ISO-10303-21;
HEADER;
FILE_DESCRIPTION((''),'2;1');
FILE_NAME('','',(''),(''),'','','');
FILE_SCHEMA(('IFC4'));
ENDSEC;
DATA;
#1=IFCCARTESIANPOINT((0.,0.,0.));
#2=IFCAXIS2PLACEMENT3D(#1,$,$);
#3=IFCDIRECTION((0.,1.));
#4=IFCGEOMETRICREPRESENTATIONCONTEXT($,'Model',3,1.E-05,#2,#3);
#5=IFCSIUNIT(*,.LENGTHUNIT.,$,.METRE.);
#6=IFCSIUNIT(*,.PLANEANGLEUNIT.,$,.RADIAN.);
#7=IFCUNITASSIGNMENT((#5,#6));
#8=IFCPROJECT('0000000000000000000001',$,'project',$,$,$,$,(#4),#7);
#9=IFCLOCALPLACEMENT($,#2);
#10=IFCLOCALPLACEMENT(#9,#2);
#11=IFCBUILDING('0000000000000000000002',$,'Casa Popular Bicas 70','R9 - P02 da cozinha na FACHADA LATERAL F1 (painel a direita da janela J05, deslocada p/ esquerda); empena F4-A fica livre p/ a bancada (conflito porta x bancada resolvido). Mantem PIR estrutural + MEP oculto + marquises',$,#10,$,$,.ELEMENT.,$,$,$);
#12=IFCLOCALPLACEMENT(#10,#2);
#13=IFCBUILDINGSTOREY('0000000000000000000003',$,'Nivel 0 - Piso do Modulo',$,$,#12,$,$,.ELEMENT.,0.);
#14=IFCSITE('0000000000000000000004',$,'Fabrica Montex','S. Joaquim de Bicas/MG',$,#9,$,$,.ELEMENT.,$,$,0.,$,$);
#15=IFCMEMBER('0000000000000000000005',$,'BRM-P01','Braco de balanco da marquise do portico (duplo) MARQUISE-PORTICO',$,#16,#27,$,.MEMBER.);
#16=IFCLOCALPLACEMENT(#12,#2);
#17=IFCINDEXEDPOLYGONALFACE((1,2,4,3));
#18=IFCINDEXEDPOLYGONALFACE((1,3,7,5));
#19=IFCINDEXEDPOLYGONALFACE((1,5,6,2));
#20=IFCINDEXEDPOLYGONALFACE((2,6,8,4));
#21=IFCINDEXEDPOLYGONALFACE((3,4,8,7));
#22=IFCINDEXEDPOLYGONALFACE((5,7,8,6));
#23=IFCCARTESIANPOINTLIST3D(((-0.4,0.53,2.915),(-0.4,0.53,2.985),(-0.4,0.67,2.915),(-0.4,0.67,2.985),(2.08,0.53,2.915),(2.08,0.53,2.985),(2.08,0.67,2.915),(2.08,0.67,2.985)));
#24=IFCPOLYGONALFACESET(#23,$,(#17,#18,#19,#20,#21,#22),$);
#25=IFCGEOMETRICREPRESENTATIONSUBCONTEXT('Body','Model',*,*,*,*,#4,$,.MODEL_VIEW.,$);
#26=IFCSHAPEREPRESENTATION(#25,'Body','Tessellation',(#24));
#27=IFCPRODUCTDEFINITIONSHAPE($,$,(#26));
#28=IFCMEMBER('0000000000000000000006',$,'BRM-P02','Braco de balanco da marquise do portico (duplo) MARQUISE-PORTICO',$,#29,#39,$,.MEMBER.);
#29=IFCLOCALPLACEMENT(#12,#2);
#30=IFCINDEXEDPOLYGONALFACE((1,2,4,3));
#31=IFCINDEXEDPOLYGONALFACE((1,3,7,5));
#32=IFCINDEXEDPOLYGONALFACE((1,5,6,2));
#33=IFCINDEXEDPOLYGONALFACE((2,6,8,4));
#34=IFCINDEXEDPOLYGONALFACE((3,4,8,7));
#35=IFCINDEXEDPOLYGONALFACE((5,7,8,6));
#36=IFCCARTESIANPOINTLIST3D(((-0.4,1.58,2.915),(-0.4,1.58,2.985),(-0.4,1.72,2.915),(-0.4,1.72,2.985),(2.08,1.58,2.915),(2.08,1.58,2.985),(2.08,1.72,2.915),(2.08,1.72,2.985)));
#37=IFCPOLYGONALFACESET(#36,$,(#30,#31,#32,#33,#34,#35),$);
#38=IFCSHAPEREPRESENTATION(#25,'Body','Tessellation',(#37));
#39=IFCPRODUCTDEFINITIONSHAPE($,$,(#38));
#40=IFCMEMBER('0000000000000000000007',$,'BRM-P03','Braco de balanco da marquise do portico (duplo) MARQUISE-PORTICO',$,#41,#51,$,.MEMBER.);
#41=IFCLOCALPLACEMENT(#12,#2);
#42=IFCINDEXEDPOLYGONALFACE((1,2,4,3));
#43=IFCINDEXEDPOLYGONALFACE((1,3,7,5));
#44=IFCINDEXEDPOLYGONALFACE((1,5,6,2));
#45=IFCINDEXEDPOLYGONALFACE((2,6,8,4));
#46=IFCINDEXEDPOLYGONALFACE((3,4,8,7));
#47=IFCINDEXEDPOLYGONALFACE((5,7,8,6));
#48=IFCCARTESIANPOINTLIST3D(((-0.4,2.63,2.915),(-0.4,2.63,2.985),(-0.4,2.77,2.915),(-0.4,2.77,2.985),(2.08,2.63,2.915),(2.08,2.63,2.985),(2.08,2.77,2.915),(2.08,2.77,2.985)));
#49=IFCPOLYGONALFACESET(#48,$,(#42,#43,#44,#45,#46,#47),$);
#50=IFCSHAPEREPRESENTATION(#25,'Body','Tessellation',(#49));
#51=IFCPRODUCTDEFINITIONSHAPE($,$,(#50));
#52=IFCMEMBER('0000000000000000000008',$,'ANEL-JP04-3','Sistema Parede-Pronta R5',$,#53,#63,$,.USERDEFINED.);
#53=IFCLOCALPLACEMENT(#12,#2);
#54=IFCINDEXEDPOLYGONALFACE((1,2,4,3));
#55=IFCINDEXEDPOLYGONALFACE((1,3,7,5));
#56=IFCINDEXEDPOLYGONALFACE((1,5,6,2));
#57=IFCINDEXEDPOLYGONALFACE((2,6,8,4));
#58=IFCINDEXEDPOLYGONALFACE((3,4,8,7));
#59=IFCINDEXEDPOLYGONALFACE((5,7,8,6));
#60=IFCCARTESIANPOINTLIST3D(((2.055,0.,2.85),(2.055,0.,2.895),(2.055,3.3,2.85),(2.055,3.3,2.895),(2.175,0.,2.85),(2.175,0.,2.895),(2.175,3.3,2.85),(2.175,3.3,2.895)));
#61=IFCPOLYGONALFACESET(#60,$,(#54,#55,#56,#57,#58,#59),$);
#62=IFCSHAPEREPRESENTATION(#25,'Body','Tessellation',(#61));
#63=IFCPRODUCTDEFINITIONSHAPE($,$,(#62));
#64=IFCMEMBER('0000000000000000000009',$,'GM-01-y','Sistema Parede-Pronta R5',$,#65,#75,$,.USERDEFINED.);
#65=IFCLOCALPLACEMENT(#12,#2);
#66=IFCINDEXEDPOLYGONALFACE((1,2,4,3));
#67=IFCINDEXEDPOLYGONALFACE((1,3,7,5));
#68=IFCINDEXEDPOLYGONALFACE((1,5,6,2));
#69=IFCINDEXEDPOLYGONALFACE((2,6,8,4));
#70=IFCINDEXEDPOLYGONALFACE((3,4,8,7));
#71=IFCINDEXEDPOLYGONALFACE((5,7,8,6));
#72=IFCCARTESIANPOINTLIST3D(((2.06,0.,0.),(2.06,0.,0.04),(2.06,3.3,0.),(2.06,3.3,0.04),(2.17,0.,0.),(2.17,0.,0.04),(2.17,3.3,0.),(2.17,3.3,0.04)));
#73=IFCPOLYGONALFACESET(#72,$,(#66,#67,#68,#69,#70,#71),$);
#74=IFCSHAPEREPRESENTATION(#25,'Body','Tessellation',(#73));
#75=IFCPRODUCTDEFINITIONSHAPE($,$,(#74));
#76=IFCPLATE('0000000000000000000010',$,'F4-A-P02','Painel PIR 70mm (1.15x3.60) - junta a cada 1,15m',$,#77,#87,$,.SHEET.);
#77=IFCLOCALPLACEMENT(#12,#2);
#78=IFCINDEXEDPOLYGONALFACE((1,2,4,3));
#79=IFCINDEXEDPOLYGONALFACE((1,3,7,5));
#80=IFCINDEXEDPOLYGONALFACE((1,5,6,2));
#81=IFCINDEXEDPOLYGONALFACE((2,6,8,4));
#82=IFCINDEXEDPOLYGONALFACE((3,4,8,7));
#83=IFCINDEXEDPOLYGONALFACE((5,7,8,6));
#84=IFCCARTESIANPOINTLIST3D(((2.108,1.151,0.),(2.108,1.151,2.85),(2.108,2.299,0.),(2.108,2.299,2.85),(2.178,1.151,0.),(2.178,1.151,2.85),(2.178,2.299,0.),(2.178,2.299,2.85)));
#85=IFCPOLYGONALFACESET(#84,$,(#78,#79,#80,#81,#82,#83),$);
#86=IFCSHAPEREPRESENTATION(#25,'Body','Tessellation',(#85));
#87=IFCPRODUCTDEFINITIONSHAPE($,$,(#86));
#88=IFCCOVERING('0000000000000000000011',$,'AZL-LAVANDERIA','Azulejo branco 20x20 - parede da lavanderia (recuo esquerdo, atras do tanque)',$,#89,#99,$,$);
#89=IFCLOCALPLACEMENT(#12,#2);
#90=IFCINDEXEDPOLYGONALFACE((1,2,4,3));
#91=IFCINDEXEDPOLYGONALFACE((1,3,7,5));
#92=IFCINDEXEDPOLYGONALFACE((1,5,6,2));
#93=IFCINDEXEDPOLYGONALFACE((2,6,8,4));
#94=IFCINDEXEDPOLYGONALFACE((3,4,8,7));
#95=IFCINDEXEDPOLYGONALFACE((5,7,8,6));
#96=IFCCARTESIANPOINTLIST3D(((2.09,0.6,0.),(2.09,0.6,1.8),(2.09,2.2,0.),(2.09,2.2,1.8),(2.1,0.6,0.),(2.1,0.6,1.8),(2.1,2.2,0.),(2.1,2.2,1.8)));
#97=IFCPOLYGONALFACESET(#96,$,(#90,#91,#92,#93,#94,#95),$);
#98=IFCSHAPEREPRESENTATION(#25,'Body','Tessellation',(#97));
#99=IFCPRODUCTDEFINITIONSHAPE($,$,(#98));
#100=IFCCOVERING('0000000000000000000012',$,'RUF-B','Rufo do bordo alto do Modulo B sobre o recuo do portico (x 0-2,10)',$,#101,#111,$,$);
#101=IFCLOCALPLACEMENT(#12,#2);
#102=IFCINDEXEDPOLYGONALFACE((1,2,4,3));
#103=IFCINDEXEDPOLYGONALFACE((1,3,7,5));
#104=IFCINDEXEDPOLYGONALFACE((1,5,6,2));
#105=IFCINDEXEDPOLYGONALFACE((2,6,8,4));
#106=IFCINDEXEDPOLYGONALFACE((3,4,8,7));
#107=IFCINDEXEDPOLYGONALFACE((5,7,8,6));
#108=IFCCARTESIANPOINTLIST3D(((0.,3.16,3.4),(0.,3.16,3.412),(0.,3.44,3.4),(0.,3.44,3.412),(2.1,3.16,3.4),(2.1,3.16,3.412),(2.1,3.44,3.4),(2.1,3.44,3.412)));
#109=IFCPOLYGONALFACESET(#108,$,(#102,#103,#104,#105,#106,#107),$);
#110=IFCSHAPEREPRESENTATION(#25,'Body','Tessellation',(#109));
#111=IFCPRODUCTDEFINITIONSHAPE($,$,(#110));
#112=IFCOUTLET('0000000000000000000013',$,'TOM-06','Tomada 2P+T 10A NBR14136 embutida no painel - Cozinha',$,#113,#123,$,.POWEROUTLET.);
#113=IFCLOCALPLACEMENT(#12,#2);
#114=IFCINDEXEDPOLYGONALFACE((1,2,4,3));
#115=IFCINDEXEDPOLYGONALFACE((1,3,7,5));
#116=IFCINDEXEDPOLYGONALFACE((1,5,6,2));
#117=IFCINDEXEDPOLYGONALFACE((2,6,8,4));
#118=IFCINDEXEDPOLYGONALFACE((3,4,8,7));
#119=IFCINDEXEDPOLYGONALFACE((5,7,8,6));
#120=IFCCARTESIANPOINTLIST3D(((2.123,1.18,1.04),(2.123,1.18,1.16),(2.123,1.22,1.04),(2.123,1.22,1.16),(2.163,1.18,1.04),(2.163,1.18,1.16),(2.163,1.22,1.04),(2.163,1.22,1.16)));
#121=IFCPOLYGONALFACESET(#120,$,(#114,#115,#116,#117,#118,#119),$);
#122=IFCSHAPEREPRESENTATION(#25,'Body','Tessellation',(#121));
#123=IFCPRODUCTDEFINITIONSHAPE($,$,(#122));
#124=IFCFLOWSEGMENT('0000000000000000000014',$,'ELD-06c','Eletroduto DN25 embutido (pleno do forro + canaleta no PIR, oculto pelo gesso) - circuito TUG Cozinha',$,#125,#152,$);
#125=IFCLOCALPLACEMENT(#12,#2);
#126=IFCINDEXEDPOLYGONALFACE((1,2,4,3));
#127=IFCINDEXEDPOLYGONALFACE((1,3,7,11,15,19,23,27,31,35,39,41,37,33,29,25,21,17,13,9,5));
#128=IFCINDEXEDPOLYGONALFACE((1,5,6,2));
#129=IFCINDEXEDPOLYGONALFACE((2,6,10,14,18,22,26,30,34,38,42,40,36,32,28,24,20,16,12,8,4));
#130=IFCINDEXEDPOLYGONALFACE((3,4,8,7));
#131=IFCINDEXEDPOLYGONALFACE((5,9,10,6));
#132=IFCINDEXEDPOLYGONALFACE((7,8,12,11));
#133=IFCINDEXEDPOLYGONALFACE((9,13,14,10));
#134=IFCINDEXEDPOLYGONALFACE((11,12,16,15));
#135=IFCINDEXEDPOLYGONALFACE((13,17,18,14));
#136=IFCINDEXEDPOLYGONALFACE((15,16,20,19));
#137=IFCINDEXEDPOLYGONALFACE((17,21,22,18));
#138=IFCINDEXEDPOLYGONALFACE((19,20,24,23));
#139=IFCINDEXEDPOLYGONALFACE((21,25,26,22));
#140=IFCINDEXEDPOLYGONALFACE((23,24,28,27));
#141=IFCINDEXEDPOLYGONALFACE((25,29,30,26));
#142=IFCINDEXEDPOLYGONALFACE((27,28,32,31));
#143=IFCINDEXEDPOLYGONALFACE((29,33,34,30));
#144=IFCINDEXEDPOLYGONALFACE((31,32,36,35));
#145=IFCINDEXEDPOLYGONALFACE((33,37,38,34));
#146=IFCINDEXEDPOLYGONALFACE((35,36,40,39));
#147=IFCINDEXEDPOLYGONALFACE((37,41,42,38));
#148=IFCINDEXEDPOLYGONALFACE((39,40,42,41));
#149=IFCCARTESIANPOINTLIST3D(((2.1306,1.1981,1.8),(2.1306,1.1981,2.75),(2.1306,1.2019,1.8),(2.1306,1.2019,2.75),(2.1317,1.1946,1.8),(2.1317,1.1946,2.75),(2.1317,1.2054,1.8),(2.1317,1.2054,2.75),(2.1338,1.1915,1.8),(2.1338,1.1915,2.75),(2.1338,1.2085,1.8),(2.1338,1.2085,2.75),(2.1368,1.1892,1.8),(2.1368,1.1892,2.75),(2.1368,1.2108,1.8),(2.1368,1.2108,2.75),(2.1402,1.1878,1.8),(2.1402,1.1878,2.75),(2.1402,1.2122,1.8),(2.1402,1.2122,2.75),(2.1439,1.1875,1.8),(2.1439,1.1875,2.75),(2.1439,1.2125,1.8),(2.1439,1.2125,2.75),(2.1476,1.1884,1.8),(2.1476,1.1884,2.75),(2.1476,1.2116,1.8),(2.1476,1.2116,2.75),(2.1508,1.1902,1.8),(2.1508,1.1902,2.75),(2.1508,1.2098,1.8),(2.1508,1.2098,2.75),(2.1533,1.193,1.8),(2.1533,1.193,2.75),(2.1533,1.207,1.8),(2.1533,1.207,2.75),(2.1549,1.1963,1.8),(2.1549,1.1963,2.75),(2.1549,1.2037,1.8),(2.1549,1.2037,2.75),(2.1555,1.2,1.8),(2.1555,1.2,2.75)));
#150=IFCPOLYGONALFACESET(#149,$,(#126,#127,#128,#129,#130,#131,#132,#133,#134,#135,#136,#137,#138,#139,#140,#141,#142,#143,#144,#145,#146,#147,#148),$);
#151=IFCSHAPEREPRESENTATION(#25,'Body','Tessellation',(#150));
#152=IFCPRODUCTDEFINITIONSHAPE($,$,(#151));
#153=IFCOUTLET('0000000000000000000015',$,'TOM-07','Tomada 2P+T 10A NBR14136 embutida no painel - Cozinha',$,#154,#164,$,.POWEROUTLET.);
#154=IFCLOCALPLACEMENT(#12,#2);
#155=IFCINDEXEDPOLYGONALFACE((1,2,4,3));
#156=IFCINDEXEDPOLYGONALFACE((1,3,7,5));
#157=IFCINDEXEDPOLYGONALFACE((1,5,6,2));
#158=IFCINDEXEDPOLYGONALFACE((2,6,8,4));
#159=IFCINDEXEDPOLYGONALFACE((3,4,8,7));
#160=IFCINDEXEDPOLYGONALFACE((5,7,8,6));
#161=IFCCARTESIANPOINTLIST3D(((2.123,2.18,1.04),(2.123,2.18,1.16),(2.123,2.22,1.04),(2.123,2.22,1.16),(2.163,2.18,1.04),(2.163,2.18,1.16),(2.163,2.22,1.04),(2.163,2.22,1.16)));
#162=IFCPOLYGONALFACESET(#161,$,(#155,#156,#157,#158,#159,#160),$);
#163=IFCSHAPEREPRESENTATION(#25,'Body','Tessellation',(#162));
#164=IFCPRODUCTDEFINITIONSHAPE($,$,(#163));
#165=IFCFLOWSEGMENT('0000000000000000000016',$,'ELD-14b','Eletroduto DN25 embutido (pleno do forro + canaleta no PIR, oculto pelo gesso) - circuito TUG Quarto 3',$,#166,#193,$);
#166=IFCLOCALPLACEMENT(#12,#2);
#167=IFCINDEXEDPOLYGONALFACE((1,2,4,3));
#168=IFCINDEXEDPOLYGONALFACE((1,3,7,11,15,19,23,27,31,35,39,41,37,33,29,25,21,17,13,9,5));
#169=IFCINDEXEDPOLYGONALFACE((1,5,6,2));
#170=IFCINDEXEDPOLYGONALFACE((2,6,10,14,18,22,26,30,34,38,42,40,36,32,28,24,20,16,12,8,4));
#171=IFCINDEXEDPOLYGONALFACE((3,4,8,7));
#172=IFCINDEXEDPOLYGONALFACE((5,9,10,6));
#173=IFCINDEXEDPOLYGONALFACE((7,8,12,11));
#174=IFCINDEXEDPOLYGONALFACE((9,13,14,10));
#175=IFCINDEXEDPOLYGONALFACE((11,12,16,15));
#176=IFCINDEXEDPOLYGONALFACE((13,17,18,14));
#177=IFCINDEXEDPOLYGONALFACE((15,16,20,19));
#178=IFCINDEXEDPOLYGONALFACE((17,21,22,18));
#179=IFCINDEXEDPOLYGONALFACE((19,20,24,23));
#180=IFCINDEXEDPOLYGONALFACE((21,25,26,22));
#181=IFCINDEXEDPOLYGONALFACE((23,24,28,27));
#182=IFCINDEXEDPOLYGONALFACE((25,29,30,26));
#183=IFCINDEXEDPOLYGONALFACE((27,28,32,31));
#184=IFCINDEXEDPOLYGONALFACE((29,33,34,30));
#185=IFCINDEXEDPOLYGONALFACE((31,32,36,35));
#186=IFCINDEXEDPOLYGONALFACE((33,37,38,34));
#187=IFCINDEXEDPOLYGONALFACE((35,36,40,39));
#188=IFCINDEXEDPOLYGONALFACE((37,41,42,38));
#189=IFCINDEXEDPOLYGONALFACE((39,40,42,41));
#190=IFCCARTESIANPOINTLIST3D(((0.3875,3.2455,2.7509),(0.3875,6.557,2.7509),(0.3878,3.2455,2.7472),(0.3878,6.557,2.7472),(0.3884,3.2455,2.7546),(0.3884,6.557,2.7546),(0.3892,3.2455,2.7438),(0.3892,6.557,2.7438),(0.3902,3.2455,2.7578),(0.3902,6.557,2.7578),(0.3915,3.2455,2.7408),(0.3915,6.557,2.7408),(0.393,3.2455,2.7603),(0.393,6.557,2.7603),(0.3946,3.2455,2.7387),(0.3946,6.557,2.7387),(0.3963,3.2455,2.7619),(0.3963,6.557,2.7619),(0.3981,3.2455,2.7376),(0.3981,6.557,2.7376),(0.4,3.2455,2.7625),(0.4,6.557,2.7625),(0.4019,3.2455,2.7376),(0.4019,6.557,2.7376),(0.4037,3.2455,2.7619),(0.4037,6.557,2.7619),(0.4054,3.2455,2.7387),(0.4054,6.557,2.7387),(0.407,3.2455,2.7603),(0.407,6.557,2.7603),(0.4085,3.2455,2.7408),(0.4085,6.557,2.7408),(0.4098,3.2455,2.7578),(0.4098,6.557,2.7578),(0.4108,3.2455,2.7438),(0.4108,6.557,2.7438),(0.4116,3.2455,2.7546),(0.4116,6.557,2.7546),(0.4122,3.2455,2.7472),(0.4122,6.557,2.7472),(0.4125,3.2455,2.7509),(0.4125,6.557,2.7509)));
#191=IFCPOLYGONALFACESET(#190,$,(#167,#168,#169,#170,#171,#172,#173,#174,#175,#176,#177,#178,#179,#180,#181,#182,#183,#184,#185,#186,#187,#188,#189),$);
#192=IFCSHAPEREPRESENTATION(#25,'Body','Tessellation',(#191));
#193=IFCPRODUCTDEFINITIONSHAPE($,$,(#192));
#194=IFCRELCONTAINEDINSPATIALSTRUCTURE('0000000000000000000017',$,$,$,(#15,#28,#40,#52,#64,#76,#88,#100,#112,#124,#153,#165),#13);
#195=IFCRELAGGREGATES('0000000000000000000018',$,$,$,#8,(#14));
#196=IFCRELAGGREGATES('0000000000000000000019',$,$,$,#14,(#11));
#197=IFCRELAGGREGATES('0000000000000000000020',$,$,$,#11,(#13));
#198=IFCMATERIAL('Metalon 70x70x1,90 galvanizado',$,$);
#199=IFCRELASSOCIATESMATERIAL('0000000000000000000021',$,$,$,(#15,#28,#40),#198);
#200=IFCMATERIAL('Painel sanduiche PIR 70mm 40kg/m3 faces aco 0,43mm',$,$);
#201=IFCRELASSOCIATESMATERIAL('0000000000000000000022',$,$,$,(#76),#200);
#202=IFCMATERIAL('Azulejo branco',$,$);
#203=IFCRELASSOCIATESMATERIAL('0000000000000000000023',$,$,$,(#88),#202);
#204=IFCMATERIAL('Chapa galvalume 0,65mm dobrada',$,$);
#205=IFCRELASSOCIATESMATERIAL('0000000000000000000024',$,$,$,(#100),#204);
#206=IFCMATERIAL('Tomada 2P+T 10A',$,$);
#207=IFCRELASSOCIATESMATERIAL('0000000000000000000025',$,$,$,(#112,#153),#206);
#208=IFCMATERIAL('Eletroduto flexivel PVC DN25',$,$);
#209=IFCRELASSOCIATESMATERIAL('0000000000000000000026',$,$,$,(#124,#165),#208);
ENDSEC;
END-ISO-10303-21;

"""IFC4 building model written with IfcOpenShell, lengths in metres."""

from ifc_helpers import new_model, si_unit, direction, frame, frame_2d, origin, origin_2d, place, context, subcontext, project, spatial, rectangle, circle, extrude, material, element, save


model = new_model("IFC4")

# Units and contexts
model_context = context("Model", 3, precision=1e-05, world=origin(), true_north=direction((0.0, 1.0)))
body_context = subcontext(model_context, "Body", "Model", "MODEL_VIEW")
ifc_project = project(units=[si_unit("LENGTHUNIT", "METRE"), si_unit("PLANEANGLEUNIT", "RADIAN")], contexts=[model_context])

# Site, building, storey
site_placement = place(None, origin())
site = spatial("IfcSite", under=ifc_project, at=site_placement, Name="Fabrica Montex", Description="S. Joaquim de Bicas/MG", CompositionType="ELEMENT", RefElevation=0.0)
building_placement = place(site_placement, origin())
building = spatial("IfcBuilding", under=site, at=building_placement, Name="Casa Popular Bicas 70", Description="R9 - P02 da cozinha na FACHADA LATERAL F1 (painel a direita da janela J05, deslocada p/ esquerda); empena F4-A fica livre p/ a bancada (conflito porta x bancada resolvido). Mantem PIR estrutural + MEP oculto + marquises", CompositionType="ELEMENT")
storey_placement = place(building_placement, origin())
storey = spatial("IfcBuildingStorey", under=building, at=storey_placement, Name="Nivel 0 - Piso do Modulo", CompositionType="ELEMENT", Elevation=0.0)

# Members
ifc_material_1 = material(Name="Metalon 70x70x1,90 galvanizado")
for number, where, z_axis, x_axis, name in (
    (1, (2.08, 0.6, 2.95), (-1.0, 0.0, 0.0), (0.0, 0.0, 1.0), "BRM-P01"),
    (2, (2.08, 1.65, 2.95), (-1.0, 0.0, 0.0), (0.0, 0.0, 1.0), "BRM-P02"),
    (3, (2.08, 2.7, 2.95), (-1.0, 0.0, 0.0), (0.0, 0.0, 1.0), "BRM-P03"),
):
    element("IfcMember", number, at=place(storey_placement, frame(where, z_axis=z_axis, x_axis=x_axis)), inside=storey, material=ifc_material_1, Name=name, Description="Braco de balanco da marquise do portico (duplo) MARQUISE-PORTICO", PredefinedType="MEMBER", context=body_context, shape_type="SweptSolid", body=[
        extrude(rectangle(XDim=0.07, YDim=0.14, at=origin_2d()), origin(), (0.0, 0.0, 1.0), 2.48),
    ])
member_1_placement = place(storey_placement, frame((2.115, 1.65, 2.85)))
element("IfcMember", 4, at=member_1_placement, inside=storey, Name="ANEL-JP04-3", Description="Sistema Parede-Pronta R5", PredefinedType="USERDEFINED", context=body_context, shape_type="SweptSolid", body=[
    extrude(rectangle(XDim=0.12, YDim=3.3, at=origin_2d()), origin(), (0.0, 0.0, 1.0), 0.045),
])
member_2_placement = place(storey_placement, frame((2.115, 1.65, 0.0)))
element("IfcMember", 5, at=member_2_placement, inside=storey, Name="GM-01-y", Description="Sistema Parede-Pronta R5", PredefinedType="USERDEFINED", context=body_context, shape_type="SweptSolid", body=[
    extrude(rectangle(XDim=0.11, YDim=3.3, at=origin_2d()), origin(), (0.0, 0.0, 1.0), 0.04),
])

# Plate
ifc_material_2 = material(Name="Painel sanduiche PIR 70mm 40kg/m3 faces aco 0,43mm")
plate_placement = place(storey_placement, frame((2.143, 1.151, 0.0), x_axis=(0.0, 1.0, 0.0)))
element("IfcPlate", 6, at=plate_placement, inside=storey, material=ifc_material_2, Name="F4-A-P02", Description="Painel PIR 70mm (1.15x3.60) - junta a cada 1,15m", PredefinedType="SHEET", context=body_context, shape_type="SweptSolid", body=[
    extrude(rectangle(XDim=1.148, YDim=0.07, at=frame_2d((0.574, 0.0))), origin(), (0.0, 0.0, 1.0), 2.85),
])

# Coverings
ifc_material_3 = material(Name="Azulejo branco")
covering_1_placement = place(storey_placement, frame((2.095, 0.6, 0.0), x_axis=(0.0, 1.0, 0.0)))
element("IfcCovering", 7, at=covering_1_placement, inside=storey, material=ifc_material_3, Name="AZL-LAVANDERIA", Description="Azulejo branco 20x20 - parede da lavanderia (recuo esquerdo, atras do tanque)", context=body_context, shape_type="SweptSolid", body=[
    extrude(rectangle(XDim=1.6, YDim=0.01, at=frame_2d((0.8, 0.0))), origin(), (0.0, 0.0, 1.0), 1.8),
])
ifc_material_4 = material(Name="Chapa galvalume 0,65mm dobrada")
covering_2_placement = place(storey_placement, frame((0.0, 3.16, 3.4), x_axis=(1.0, 0.0, 0.0)))
element("IfcCovering", 8, at=covering_2_placement, inside=storey, material=ifc_material_4, Name="RUF-B", Description="Rufo do bordo alto do Modulo B sobre o recuo do portico (x 0-2,10)", context=body_context, shape_type="SweptSolid", body=[
    extrude(rectangle(XDim=2.1, YDim=0.28, at=frame_2d((1.05, 0.14))), origin(), (0.0, 0.0, 1.0), 0.012),
])

# Outlet
ifc_material_5 = material(Name="Tomada 2P+T 10A")
outlet_1_placement = place(storey_placement, frame((2.123, 1.18, 1.04)))
element("IfcOutlet", 9, at=outlet_1_placement, inside=storey, material=ifc_material_5, Name="TOM-06", Description="Tomada 2P+T 10A NBR14136 embutida no painel - Cozinha", PredefinedType="POWEROUTLET", context=body_context, shape_type="SweptSolid", body=[
    extrude(rectangle(XDim=0.04, YDim=0.04, at=frame_2d((0.02, 0.02))), origin(), (0.0, 0.0, 1.0), 0.12),
])

# Flow segment
ifc_material_6 = material(Name="Eletroduto flexivel PVC DN25")
flow_segment_1_placement = place(storey_placement, frame((2.143, 1.2, 2.75), z_axis=(0.0, 0.0, -1.0), x_axis=(1.0, 0.0, 0.0)))
element("IfcFlowSegment", 10, at=flow_segment_1_placement, inside=storey, material=ifc_material_6, Name="ELD-06c", Description="Eletroduto DN25 embutido (pleno do forro + canaleta no PIR, oculto pelo gesso) - circuito TUG Cozinha", context=body_context, shape_type="SweptSolid", body=[
    extrude(circle(Radius=0.0125, at=origin_2d()), origin(), (0.0, 0.0, 1.0), 0.95),
])

# Outlet
outlet_2_placement = place(storey_placement, frame((2.123, 2.18, 1.04)))
element("IfcOutlet", 11, at=outlet_2_placement, inside=storey, material=ifc_material_5, Name="TOM-07", Description="Tomada 2P+T 10A NBR14136 embutida no painel - Cozinha", PredefinedType="POWEROUTLET", context=body_context, shape_type="SweptSolid", body=[
    extrude(rectangle(XDim=0.04, YDim=0.04, at=frame_2d((0.02, 0.02))), origin(), (0.0, 0.0, 1.0), 0.12),
])

# Flow segment
flow_segment_2_placement = place(storey_placement, frame((0.4, 3.2455, 2.75), z_axis=(0.0, 1.0, 0.0), x_axis=(0.0, 0.0, 1.0)))
element("IfcFlowSegment", 12, at=flow_segment_2_placement, inside=storey, material=ifc_material_6, Name="ELD-14b", Description="Eletroduto DN25 embutido (pleno do forro + canaleta no PIR, oculto pelo gesso) - circuito TUG Quarto 3", context=body_context, shape_type="SweptSolid", body=[
    extrude(circle(Radius=0.0125, at=origin_2d()), origin(), (0.0, 0.0, 1.0), 3.3115),
])

save(model, "model.ifc")
